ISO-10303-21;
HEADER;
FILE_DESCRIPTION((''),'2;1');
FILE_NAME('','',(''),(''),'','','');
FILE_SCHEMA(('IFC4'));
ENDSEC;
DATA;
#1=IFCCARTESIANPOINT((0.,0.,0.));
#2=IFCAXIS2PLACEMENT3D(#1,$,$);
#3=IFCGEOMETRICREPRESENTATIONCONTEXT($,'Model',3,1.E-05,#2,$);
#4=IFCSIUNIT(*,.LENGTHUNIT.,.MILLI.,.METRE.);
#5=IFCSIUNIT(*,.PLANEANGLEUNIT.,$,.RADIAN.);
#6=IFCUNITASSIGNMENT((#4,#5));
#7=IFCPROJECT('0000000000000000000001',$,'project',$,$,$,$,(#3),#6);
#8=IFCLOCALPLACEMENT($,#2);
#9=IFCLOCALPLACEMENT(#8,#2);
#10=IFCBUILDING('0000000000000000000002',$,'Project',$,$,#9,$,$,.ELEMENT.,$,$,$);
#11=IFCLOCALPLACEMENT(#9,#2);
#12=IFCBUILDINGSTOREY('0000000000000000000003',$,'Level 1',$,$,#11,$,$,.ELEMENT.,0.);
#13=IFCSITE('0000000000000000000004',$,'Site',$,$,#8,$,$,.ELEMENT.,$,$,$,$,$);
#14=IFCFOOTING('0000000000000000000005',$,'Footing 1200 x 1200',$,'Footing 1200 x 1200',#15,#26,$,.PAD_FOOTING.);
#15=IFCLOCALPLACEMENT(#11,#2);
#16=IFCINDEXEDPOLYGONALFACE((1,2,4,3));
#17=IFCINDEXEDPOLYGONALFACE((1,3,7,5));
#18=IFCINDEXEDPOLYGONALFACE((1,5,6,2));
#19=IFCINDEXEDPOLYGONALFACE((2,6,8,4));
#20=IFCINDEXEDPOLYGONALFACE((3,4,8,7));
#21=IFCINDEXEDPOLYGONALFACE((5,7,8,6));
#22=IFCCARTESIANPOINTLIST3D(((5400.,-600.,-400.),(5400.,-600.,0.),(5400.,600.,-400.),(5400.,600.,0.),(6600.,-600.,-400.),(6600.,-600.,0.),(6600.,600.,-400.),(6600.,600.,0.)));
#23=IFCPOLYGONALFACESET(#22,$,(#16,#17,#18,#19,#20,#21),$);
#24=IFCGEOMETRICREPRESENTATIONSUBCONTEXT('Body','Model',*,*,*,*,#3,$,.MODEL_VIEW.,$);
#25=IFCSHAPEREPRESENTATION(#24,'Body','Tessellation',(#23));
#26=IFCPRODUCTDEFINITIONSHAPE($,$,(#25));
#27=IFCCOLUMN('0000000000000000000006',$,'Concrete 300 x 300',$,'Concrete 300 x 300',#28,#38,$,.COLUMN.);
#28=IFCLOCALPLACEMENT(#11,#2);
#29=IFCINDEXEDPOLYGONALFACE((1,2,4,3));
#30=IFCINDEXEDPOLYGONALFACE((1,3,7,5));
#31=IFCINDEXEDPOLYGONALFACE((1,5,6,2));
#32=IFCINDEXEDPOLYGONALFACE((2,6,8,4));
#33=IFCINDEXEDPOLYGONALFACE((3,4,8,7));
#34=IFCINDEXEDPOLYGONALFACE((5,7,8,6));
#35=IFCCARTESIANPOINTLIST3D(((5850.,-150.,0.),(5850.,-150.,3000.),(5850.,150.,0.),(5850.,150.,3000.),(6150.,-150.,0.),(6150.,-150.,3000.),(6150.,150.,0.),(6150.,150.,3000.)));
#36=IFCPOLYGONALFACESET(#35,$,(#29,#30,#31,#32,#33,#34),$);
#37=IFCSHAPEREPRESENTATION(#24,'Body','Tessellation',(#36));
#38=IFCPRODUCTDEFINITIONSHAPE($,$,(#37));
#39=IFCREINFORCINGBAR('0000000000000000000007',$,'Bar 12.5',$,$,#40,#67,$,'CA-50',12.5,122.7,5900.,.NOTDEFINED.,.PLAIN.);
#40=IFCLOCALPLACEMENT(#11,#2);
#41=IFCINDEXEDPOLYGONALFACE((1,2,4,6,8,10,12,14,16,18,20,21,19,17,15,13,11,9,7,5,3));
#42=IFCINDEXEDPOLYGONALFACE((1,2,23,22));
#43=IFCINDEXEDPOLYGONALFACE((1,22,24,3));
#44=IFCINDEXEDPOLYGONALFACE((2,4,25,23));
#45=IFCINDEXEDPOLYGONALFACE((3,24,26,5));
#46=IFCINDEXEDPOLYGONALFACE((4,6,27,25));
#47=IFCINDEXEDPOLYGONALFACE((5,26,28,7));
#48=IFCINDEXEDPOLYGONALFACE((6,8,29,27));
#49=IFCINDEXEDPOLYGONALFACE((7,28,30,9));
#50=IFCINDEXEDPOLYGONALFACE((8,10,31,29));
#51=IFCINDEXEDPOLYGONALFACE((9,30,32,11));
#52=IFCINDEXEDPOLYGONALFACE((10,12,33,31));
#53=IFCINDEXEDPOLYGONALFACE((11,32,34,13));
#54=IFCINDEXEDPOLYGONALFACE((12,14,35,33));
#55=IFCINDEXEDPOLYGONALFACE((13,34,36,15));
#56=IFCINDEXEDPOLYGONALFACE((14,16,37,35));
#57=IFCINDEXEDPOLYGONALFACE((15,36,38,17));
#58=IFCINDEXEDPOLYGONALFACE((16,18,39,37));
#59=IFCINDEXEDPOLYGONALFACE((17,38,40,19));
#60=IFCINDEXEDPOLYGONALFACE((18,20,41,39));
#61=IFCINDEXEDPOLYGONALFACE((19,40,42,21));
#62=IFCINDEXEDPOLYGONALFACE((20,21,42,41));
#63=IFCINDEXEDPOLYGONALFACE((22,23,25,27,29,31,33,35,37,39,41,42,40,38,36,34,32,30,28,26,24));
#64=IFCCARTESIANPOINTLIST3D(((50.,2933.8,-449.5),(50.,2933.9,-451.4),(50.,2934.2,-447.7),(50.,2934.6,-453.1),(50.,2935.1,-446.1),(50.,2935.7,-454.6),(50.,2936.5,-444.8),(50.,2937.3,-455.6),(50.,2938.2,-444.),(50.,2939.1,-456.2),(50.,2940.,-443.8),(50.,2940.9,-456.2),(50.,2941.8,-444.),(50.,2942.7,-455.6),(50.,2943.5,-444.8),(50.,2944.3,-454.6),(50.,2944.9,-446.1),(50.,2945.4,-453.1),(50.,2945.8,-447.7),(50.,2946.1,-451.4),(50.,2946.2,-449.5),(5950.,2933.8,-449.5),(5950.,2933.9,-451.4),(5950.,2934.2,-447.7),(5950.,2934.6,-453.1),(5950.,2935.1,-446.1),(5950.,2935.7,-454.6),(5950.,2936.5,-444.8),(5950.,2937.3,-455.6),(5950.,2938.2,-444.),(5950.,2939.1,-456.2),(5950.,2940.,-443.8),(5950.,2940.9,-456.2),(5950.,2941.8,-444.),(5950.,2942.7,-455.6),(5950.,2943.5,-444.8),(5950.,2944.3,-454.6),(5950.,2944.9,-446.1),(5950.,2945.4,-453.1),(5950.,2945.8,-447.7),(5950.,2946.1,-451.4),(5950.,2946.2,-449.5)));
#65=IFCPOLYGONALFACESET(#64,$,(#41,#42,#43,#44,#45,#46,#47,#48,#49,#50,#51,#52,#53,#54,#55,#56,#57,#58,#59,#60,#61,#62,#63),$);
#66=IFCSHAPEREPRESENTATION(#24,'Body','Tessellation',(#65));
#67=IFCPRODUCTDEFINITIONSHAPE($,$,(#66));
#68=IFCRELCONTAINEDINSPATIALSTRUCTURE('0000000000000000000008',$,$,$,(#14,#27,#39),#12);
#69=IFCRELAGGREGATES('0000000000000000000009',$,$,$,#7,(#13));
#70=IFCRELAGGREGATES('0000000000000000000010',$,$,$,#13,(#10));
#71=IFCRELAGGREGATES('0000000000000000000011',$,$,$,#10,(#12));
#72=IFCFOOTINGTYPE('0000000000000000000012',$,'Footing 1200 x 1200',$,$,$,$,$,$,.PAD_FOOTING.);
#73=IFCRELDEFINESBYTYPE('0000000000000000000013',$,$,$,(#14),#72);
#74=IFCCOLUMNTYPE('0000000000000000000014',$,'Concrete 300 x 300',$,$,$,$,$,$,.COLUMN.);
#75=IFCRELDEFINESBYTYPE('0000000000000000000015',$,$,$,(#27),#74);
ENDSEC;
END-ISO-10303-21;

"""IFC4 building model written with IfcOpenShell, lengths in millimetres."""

from ifc_helpers import new_model, entity, si_unit, frame, origin, origin_2d, place, context, subcontext, project, spatial, rectangle, extrude, material_profile, profile_set, profile_usage, type_object, element, save


model = new_model("IFC4")

# Units and contexts
model_context = context("Model", 3, precision=1e-05, world=origin())
body_context = subcontext(model_context, "Body", "Model", "MODEL_VIEW")
ifc_project = project(units=[si_unit("LENGTHUNIT", "METRE", prefix="MILLI"), si_unit("PLANEANGLEUNIT", "RADIAN")], contexts=[model_context])

# Site, building, storey
site_placement = place(None, origin())
site = spatial("IfcSite", under=ifc_project, at=site_placement, Name="Site", CompositionType="ELEMENT")
building_placement = place(site_placement, origin())
building = spatial("IfcBuilding", under=site, at=building_placement, Name="Project", CompositionType="ELEMENT")
storey_placement = place(building_placement, origin())
storey = spatial("IfcBuildingStorey", under=building, at=storey_placement, Name="Level 1", CompositionType="ELEMENT", Elevation=0.0)

# Footing
ifc_material_profile_1 = material_profile(None, rectangle(XDim=1200.0, YDim=1200.0, at=origin_2d()), Name="Footing 1200 x 1200")
ifc_profile_set_1 = profile_set([ifc_material_profile_1], Name="Footing 1200 x 1200")
ifc_profile_usage_1 = profile_usage(ifc_profile_set_1, cardinal=5)
footing_type = type_object("IfcFootingType", Name="Footing 1200 x 1200", PredefinedType="PAD_FOOTING", material=ifc_profile_set_1)
footing_placement = place(storey_placement, frame((6000.0, 0.0, -400.0), z_axis=(0.0, 0.0, 1.0), x_axis=(1.0, 0.0, 0.0)))
element("IfcFooting", 1, at=footing_placement, inside=storey, type_object=footing_type, material=ifc_profile_usage_1, Name="Footing 1200 x 1200", ObjectType="Footing 1200 x 1200", PredefinedType="PAD_FOOTING", context=body_context, shape_type="SweptSolid", body=[
    extrude(rectangle(XDim=1200.0, YDim=1200.0, at=origin_2d()), origin(), (0.0, 0.0, 1.0), 400.0),
])

# Column
ifc_material_profile_2 = material_profile(None, rectangle(XDim=300.0, YDim=300.0, at=origin_2d()), Name="Concrete 300 x 300")
ifc_profile_set_2 = profile_set([ifc_material_profile_2], Name="Concrete 300 x 300")
ifc_profile_usage_2 = profile_usage(ifc_profile_set_2, cardinal=5)
column_type_1 = type_object("IfcColumnType", Name="Concrete 300 x 300", PredefinedType="COLUMN", material=ifc_profile_set_2)
column_1_placement = place(storey_placement, frame((6000.0, 0.0, 0.0), z_axis=(0.0, 0.0, 1.0), x_axis=(1.0, 0.0, 0.0)))
element("IfcColumn", 2, at=column_1_placement, inside=storey, type_object=column_type_1, material=ifc_profile_usage_2, Name="Concrete 300 x 300", ObjectType="Concrete 300 x 300", PredefinedType="COLUMN", context=body_context, shape_type="SweptSolid", body=[
    extrude(rectangle(XDim=300.0, YDim=300.0, at=origin_2d()), origin(), (0.0, 0.0, 1.0), 3000.0),
])

# Reinforcing bar
reinforcing_bar_1_placement = place(storey_placement, origin())
element("IfcReinforcingBar", 3, at=reinforcing_bar_1_placement, inside=storey, Name="Bar 12.5", SteelGrade="CA-50", BarLength=5900.0, BarSurface="PLAIN", CrossSectionArea=122.7, NominalDiameter=12.5, PredefinedType="NOTDEFINED", context=body_context, shape_type="AdvancedSweptSolid", body=[
    entity("IfcSweptDiskSolid", entity("IfcPolyline", [entity("IfcCartesianPoint", [50.0, 2940.0, -450.0]), entity("IfcCartesianPoint", [5950.0, 2940.0, -450.0])]), 6.2),
])

save(model, "model.ifc")
